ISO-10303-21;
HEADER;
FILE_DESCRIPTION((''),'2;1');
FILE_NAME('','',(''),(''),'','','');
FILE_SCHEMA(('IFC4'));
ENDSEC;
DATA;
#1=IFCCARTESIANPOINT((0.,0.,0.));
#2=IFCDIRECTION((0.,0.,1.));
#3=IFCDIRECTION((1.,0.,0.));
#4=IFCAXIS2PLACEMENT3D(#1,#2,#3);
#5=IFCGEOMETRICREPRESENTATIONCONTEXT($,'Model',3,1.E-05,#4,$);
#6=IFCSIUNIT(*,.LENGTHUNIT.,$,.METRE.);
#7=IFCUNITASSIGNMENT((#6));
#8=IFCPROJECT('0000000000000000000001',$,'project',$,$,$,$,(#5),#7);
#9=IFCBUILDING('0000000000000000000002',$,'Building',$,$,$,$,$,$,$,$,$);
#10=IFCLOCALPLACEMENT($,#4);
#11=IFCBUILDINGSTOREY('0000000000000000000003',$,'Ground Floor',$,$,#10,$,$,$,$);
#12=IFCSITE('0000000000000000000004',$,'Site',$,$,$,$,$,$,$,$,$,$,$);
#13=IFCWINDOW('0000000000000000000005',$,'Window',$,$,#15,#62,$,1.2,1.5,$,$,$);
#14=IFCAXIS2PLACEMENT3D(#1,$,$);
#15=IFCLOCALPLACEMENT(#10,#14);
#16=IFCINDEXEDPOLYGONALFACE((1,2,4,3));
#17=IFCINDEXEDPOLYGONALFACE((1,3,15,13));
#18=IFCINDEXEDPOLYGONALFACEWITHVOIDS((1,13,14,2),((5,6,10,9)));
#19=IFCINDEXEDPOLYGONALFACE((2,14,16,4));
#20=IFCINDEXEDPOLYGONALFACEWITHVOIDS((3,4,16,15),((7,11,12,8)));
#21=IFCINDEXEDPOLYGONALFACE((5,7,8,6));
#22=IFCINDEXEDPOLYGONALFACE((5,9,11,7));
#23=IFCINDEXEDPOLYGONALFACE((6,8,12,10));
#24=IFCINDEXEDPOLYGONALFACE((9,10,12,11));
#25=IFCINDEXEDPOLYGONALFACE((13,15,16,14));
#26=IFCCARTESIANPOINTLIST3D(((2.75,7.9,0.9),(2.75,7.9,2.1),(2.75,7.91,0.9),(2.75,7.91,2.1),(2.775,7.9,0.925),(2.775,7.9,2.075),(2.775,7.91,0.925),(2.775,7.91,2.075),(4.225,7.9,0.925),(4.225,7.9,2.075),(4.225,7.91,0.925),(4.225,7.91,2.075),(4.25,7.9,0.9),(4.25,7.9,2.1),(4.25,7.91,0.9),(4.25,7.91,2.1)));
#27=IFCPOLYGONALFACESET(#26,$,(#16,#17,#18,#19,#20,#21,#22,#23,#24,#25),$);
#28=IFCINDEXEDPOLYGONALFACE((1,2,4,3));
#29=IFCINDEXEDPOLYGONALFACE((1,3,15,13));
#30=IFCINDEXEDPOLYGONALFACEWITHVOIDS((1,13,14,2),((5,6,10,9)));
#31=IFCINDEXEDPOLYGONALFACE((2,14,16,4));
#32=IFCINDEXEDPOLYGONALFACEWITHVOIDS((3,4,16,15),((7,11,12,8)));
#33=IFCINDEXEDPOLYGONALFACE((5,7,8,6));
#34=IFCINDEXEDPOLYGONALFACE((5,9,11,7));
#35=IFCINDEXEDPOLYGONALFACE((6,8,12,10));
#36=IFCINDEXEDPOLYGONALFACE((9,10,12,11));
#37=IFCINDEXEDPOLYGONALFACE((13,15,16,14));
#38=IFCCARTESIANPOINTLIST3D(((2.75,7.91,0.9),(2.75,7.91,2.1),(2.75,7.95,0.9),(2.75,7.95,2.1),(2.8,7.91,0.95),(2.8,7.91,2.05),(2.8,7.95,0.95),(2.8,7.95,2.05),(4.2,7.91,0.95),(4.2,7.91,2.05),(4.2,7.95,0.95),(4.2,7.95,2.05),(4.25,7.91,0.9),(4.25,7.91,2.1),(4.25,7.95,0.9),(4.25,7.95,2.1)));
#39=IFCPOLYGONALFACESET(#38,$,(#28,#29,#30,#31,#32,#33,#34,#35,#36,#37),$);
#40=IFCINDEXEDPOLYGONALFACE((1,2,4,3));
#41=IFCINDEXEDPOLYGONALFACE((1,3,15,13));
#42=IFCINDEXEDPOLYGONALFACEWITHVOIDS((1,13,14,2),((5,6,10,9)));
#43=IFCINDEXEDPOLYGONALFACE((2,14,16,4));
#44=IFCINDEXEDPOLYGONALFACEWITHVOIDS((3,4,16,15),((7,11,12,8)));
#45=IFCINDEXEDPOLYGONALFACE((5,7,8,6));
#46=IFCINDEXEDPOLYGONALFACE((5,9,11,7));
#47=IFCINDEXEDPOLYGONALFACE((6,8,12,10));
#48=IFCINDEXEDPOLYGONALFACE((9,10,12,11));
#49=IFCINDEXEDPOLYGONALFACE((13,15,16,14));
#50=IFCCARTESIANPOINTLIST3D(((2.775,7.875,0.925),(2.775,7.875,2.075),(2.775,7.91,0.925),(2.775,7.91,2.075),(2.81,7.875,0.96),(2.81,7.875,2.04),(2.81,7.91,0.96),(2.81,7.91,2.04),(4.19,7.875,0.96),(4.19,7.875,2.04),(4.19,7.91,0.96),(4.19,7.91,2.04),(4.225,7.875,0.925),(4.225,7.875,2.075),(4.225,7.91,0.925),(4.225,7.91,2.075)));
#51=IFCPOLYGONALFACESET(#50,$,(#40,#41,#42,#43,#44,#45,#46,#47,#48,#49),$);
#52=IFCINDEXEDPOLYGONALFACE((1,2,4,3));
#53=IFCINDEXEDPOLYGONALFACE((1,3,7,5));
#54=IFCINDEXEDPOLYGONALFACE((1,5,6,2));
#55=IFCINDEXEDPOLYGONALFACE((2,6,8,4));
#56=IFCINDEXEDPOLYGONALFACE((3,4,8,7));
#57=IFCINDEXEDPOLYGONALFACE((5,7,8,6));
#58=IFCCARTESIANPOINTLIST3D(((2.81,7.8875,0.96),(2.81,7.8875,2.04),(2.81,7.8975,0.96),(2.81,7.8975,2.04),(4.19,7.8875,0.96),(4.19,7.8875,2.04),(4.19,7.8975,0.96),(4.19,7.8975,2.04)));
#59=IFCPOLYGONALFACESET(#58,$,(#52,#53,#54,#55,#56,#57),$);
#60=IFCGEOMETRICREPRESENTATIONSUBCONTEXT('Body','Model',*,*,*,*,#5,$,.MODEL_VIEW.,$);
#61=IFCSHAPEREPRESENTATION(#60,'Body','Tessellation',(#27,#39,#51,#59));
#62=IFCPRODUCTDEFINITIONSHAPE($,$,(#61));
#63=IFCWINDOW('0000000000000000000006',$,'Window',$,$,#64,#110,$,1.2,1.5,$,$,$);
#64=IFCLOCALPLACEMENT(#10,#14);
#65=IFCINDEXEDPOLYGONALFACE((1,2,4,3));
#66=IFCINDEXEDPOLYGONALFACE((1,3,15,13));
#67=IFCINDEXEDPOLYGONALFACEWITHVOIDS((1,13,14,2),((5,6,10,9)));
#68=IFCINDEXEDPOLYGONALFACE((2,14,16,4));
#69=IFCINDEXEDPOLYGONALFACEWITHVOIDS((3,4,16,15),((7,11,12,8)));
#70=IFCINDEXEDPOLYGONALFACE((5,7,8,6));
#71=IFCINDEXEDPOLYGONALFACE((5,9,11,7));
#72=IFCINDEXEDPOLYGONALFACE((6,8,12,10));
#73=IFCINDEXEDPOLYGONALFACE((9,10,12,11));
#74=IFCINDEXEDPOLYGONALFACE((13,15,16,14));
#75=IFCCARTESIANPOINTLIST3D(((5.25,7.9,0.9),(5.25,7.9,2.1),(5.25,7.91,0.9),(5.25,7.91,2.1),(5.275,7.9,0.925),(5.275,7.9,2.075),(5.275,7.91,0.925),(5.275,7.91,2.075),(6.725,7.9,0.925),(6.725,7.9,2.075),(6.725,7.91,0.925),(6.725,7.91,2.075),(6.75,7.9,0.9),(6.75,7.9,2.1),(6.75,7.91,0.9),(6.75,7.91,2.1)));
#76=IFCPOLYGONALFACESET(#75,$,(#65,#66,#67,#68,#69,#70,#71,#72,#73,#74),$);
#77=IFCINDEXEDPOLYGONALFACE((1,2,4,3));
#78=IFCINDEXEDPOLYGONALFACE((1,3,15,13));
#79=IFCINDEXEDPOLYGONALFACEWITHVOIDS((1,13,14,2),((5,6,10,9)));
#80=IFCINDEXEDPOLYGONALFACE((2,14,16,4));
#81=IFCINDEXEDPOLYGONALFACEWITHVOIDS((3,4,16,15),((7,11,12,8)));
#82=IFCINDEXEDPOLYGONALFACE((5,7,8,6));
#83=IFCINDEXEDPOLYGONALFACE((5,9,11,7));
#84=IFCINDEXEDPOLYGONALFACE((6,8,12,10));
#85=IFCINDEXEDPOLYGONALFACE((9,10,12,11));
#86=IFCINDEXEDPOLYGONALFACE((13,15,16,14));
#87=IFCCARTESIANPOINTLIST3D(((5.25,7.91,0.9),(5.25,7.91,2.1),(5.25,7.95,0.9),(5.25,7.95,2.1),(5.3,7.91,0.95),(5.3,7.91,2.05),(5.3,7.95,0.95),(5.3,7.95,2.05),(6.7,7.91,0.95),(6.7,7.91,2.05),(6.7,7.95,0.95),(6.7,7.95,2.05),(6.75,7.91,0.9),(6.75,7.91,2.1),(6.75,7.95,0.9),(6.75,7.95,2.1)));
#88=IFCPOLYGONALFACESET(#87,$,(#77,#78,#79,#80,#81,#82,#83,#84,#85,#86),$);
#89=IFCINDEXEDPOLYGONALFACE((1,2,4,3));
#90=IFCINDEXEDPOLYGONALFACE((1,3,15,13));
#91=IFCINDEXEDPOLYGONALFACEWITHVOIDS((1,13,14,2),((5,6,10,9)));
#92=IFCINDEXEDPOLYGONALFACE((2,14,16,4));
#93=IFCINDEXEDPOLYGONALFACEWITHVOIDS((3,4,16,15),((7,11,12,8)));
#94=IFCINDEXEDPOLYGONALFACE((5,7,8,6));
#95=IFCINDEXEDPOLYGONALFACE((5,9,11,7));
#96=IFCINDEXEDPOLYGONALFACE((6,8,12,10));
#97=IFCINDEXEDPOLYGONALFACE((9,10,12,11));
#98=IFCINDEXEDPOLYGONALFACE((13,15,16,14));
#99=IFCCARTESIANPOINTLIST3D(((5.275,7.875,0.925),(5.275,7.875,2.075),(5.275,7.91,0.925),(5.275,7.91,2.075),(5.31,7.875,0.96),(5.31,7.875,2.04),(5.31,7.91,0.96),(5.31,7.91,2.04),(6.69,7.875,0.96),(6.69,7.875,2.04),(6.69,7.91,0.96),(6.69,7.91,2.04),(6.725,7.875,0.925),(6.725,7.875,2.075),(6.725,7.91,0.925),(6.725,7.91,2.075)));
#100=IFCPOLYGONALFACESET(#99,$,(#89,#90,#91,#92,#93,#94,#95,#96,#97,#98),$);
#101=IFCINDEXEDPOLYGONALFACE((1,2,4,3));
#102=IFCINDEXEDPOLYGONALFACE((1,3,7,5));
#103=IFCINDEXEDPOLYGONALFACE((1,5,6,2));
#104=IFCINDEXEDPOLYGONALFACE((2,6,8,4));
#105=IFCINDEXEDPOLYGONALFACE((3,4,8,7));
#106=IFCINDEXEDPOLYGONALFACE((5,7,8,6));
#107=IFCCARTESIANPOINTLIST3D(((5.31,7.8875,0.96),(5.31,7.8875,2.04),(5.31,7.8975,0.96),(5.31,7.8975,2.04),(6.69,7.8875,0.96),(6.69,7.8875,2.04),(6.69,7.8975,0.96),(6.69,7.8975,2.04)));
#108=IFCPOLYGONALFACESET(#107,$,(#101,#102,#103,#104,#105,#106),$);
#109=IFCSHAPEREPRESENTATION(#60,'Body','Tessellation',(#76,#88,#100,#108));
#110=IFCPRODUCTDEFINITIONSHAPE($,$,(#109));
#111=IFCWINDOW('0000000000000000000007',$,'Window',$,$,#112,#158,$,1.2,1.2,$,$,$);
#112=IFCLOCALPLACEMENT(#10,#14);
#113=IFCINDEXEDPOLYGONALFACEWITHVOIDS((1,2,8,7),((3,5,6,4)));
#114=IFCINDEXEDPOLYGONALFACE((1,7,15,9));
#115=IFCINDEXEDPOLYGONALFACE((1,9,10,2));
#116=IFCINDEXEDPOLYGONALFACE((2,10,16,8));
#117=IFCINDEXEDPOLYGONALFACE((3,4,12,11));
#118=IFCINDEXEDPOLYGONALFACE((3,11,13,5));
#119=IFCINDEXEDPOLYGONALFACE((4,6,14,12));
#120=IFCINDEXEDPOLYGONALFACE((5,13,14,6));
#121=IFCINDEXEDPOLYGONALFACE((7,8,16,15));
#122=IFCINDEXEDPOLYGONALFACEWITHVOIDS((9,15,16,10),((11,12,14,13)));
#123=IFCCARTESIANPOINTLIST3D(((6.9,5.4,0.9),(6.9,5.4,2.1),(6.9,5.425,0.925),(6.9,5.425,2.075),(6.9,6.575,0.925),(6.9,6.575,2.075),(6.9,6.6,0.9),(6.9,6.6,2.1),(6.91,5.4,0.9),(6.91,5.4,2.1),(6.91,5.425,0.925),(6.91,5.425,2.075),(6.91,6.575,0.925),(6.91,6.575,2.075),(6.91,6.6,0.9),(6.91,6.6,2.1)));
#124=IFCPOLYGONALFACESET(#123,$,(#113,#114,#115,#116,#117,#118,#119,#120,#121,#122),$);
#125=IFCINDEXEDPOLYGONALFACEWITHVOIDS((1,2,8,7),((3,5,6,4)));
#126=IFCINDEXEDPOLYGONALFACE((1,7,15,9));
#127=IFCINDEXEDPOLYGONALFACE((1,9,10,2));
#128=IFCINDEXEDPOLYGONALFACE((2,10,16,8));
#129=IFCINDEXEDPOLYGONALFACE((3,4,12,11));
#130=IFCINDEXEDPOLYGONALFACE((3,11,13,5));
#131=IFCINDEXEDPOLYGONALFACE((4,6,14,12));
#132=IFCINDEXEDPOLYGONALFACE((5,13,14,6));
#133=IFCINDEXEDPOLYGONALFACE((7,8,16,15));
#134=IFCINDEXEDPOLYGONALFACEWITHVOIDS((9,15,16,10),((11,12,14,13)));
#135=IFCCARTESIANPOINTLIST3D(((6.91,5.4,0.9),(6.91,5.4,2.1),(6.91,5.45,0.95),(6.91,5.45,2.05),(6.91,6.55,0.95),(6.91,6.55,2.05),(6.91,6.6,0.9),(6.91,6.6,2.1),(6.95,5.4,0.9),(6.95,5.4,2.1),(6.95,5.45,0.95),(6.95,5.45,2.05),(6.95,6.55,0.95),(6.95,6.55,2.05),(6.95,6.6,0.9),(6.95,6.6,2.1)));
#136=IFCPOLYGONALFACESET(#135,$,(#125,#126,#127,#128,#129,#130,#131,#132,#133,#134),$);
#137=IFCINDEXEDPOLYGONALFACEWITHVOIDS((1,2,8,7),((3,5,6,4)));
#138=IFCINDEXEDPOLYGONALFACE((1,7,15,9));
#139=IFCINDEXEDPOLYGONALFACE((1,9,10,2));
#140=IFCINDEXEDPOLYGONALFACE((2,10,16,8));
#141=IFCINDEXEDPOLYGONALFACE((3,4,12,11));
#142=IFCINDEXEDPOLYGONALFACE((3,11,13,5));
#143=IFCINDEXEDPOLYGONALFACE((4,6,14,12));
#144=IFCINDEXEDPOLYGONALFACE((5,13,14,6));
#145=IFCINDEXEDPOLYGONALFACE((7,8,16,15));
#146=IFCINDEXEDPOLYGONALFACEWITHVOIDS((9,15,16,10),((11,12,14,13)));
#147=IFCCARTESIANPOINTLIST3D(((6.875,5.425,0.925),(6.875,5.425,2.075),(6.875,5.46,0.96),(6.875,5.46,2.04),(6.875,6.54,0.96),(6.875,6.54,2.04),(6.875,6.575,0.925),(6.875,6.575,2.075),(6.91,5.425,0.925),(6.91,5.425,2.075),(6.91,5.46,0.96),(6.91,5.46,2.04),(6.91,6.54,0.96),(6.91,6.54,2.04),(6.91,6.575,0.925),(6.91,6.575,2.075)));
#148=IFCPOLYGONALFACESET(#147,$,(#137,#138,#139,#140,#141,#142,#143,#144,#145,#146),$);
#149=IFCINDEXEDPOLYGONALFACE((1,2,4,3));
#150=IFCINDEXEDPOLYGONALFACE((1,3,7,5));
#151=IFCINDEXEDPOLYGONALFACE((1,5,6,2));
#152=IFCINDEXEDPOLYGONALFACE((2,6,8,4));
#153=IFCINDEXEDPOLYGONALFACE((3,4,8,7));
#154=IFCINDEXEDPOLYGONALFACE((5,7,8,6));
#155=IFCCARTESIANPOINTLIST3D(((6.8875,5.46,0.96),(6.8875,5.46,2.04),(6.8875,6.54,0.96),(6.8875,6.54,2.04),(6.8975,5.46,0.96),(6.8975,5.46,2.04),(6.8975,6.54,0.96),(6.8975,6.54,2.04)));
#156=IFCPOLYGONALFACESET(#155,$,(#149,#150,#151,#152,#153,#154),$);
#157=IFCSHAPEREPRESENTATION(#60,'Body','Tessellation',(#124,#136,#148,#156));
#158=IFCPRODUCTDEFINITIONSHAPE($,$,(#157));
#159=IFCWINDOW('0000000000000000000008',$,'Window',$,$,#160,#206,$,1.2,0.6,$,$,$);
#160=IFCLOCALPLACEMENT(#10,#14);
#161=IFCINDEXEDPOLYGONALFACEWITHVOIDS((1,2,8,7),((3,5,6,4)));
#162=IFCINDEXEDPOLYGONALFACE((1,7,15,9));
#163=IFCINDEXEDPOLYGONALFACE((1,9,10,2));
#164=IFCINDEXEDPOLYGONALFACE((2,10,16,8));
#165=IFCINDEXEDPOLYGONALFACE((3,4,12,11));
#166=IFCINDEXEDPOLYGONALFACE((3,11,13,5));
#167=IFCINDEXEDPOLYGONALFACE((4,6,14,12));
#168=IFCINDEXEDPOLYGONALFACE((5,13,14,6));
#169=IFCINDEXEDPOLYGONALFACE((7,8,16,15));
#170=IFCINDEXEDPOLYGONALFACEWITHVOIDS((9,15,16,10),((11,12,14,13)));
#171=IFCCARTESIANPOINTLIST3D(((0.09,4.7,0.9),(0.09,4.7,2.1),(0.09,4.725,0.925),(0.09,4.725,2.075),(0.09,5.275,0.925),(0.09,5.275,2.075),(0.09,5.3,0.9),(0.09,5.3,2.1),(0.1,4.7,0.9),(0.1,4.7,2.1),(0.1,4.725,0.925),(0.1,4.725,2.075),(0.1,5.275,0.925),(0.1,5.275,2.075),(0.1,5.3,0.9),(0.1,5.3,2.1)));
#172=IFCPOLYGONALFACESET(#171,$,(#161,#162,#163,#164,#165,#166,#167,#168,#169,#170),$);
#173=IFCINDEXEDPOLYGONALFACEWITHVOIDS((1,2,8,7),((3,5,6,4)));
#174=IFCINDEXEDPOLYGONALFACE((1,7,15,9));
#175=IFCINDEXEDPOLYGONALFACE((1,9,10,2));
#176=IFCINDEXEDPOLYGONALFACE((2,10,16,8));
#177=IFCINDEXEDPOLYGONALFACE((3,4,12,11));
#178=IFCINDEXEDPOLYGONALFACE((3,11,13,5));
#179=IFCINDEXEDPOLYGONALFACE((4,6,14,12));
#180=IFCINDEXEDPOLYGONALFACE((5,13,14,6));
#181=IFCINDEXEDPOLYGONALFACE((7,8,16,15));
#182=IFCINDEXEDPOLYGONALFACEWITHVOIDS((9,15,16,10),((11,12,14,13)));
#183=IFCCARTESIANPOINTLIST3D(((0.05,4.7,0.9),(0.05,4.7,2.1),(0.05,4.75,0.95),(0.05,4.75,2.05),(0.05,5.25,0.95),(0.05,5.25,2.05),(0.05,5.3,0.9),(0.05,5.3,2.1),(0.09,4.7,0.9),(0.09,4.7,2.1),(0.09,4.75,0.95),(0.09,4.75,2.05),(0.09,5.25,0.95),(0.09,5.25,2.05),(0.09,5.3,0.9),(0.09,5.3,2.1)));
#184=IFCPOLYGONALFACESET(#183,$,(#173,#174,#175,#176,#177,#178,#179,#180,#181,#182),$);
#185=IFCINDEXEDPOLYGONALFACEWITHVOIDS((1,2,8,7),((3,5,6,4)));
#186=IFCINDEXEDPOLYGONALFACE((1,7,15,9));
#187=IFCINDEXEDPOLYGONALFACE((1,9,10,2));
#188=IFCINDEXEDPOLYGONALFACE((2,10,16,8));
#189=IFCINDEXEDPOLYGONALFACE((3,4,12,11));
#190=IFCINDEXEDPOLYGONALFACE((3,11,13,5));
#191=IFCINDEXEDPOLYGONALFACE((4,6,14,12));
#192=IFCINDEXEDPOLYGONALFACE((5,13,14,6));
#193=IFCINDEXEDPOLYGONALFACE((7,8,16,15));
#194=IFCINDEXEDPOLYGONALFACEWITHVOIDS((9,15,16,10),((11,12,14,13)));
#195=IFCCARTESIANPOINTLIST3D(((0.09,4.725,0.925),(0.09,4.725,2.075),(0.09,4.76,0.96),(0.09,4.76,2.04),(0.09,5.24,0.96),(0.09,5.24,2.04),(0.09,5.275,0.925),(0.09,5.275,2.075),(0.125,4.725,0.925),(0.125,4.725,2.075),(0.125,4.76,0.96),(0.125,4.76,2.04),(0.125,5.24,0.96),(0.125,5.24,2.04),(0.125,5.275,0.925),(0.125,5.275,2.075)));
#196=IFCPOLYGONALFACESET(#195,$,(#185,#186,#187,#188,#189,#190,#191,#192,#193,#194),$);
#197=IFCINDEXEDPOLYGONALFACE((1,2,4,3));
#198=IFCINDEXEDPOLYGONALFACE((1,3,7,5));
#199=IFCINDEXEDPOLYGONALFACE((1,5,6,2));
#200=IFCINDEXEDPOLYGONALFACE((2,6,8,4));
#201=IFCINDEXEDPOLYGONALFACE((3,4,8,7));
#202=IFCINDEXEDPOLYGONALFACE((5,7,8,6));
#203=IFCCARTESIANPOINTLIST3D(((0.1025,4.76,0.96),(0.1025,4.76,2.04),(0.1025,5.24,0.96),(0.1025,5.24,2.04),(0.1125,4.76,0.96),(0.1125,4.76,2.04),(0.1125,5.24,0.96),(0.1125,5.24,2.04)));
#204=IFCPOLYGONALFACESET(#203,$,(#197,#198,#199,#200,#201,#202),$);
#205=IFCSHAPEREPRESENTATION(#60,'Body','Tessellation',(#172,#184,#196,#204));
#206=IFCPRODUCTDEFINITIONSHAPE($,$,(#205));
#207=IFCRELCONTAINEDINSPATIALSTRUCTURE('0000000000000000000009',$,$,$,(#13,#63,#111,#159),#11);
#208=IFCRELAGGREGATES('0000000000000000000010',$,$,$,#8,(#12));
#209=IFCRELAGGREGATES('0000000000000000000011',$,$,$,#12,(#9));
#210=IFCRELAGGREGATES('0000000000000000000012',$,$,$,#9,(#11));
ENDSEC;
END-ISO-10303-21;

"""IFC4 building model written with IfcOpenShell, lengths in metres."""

from ifc_helpers import new_model, si_unit, frame, origin_with_axes, place, context, subcontext, project, spatial, line, indexed_curve, outline, extrude, element, save


model = new_model("IFC4")

# Units and contexts
model_context = context("Model", 3, precision=1e-05, world=origin_with_axes())
body_context = subcontext(model_context, "Body", "Model", "MODEL_VIEW")
ifc_project = project(units=[si_unit("LENGTHUNIT", "METRE")], contexts=[model_context])

# Site, building, storey
site = spatial("IfcSite", under=ifc_project, Name="Site")
building = spatial("IfcBuilding", under=site, Name="Building")
storey_placement = place(None, origin_with_axes())
storey = spatial("IfcBuildingStorey", under=building, at=storey_placement, Name="Ground Floor")

# Windows
for number, where, z_axis, x_axis, name in (
    (1, (4.25, 8.0, 0.9), (0.0, 0.0, 1.0), (-1.0, 0.0, 0.0), "Window"),
    (2, (6.75, 8.0, 0.9), (0.0, 0.0, 1.0), (-1.0, 0.0, 0.0), "Window"),
):
    element("IfcWindow", number, at=place(storey_placement, frame(where, z_axis=z_axis, x_axis=x_axis)), inside=storey, Name=name, OverallHeight=1.2, OverallWidth=1.5, context=body_context, shape_type="SweptSolid", body=[
        extrude(outline(indexed_curve([(0.0, 0.0), (1.5, 0.0), (1.5, 1.2), (0.0, 1.2)], segments=[line(1, 2, 3, 4, 1)]), holes=[indexed_curve([(0.025, 0.025), (1.475, 0.025), (1.475, 1.175), (0.025, 1.175)], segments=[line(1, 2, 3, 4, 1)])]), frame((0.0, 0.09, 0.0), z_axis=(0.0, -1.0, 0.0), x_axis=(1.0, 0.0, 0.0)), (0.0, 0.0, -1.0), 0.01),
        extrude(outline(indexed_curve([(0.0, 0.0), (1.5, 0.0), (1.5, 1.2), (0.0, 1.2)], segments=[line(1, 2, 3, 4, 1)]), holes=[indexed_curve([(0.05, 0.05), (1.45, 0.05), (1.45, 1.15), (0.05, 1.15)], segments=[line(1, 2, 3, 4, 1)])]), frame((0.0, 0.05, 0.0), z_axis=(0.0, -1.0, 0.0), x_axis=(1.0, 0.0, 0.0)), (0.0, 0.0, -1.0), 0.04),
        extrude(outline(indexed_curve([(0.0, 0.0), (1.45, 0.0), (1.45, 1.15), (0.0, 1.15)], segments=[line(1, 2, 3, 4, 1)]), holes=[indexed_curve([(0.035, 0.035), (1.415, 0.035), (1.415, 1.115), (0.035, 1.115)], segments=[line(1, 2, 3, 4, 1)])]), frame((0.025, 0.09, 0.025), z_axis=(0.0, -1.0, 0.0), x_axis=(1.0, 0.0, 0.0)), (0.0, 0.0, -1.0), 0.035),
        extrude(outline(indexed_curve([(0.035, 0.035), (1.415, 0.035), (1.415, 1.115), (0.035, 1.115)], segments=[line(1, 2, 3, 4, 1)])), frame((0.025, 0.1025, 0.025), z_axis=(0.0, -1.0, 0.0), x_axis=(1.0, 0.0, 0.0)), (0.0, 0.0, -1.0), 0.01),
    ])
window_1_placement = place(storey_placement, frame((7.0, 5.4, 0.9), z_axis=(0.0, 0.0, 1.0), x_axis=(0.0, 1.0, 0.0)))
element("IfcWindow", 3, at=window_1_placement, inside=storey, Name="Window", OverallHeight=1.2, OverallWidth=1.2, context=body_context, shape_type="SweptSolid", body=[
    extrude(outline(indexed_curve([(0.0, 0.0), (1.2, 0.0), (1.2, 1.2), (0.0, 1.2)], segments=[line(1, 2, 3, 4, 1)]), holes=[indexed_curve([(0.025, 0.025), (1.175, 0.025), (1.175, 1.175), (0.025, 1.175)], segments=[line(1, 2, 3, 4, 1)])]), frame((0.0, 0.09, 0.0), z_axis=(0.0, -1.0, 0.0), x_axis=(1.0, 0.0, 0.0)), (0.0, 0.0, -1.0), 0.01),
    extrude(outline(indexed_curve([(0.0, 0.0), (1.2, 0.0), (1.2, 1.2), (0.0, 1.2)], segments=[line(1, 2, 3, 4, 1)]), holes=[indexed_curve([(0.05, 0.05), (1.15, 0.05), (1.15, 1.15), (0.05, 1.15)], segments=[line(1, 2, 3, 4, 1)])]), frame((0.0, 0.05, 0.0), z_axis=(0.0, -1.0, 0.0), x_axis=(1.0, 0.0, 0.0)), (0.0, 0.0, -1.0), 0.04),
    extrude(outline(indexed_curve([(0.0, 0.0), (1.15, 0.0), (1.15, 1.15), (0.0, 1.15)], segments=[line(1, 2, 3, 4, 1)]), holes=[indexed_curve([(0.035, 0.035), (1.115, 0.035), (1.115, 1.115), (0.035, 1.115)], segments=[line(1, 2, 3, 4, 1)])]), frame((0.025, 0.09, 0.025), z_axis=(0.0, -1.0, 0.0), x_axis=(1.0, 0.0, 0.0)), (0.0, 0.0, -1.0), 0.035),
    extrude(outline(indexed_curve([(0.035, 0.035), (1.115, 0.035), (1.115, 1.115), (0.035, 1.115)], segments=[line(1, 2, 3, 4, 1)])), frame((0.025, 0.1025, 0.025), z_axis=(0.0, -1.0, 0.0), x_axis=(1.0, 0.0, 0.0)), (0.0, 0.0, -1.0), 0.01),
])
window_2_placement = place(storey_placement, frame((0.0, 5.3, 0.9), z_axis=(0.0, 0.0, 1.0), x_axis=(0.0, -1.0, 0.0)))
element("IfcWindow", 4, at=window_2_placement, inside=storey, Name="Window", OverallHeight=1.2, OverallWidth=0.6, context=body_context, shape_type="SweptSolid", body=[
    extrude(outline(indexed_curve([(0.0, 0.0), (0.6, 0.0), (0.6, 1.2), (0.0, 1.2)], segments=[line(1, 2, 3, 4, 1)]), holes=[indexed_curve([(0.025, 0.025), (0.575, 0.025), (0.575, 1.175), (0.025, 1.175)], segments=[line(1, 2, 3, 4, 1)])]), frame((0.0, 0.09, 0.0), z_axis=(0.0, -1.0, 0.0), x_axis=(1.0, 0.0, 0.0)), (0.0, 0.0, -1.0), 0.01),
    extrude(outline(indexed_curve([(0.0, 0.0), (0.6, 0.0), (0.6, 1.2), (0.0, 1.2)], segments=[line(1, 2, 3, 4, 1)]), holes=[indexed_curve([(0.05, 0.05), (0.55, 0.05), (0.55, 1.15), (0.05, 1.15)], segments=[line(1, 2, 3, 4, 1)])]), frame((0.0, 0.05, 0.0), z_axis=(0.0, -1.0, 0.0), x_axis=(1.0, 0.0, 0.0)), (0.0, 0.0, -1.0), 0.04),
    extrude(outline(indexed_curve([(0.0, 0.0), (0.55, 0.0), (0.55, 1.15), (0.0, 1.15)], segments=[line(1, 2, 3, 4, 1)]), holes=[indexed_curve([(0.035, 0.035), (0.515, 0.035), (0.515, 1.115), (0.035, 1.115)], segments=[line(1, 2, 3, 4, 1)])]), frame((0.025, 0.09, 0.025), z_axis=(0.0, -1.0, 0.0), x_axis=(1.0, 0.0, 0.0)), (0.0, 0.0, -1.0), 0.035),
    extrude(outline(indexed_curve([(0.035, 0.035), (0.515, 0.035), (0.515, 1.115), (0.035, 1.115)], segments=[line(1, 2, 3, 4, 1)])), frame((0.025, 0.1025, 0.025), z_axis=(0.0, -1.0, 0.0), x_axis=(1.0, 0.0, 0.0)), (0.0, 0.0, -1.0), 0.01),
])

save(model, "model.ifc")
